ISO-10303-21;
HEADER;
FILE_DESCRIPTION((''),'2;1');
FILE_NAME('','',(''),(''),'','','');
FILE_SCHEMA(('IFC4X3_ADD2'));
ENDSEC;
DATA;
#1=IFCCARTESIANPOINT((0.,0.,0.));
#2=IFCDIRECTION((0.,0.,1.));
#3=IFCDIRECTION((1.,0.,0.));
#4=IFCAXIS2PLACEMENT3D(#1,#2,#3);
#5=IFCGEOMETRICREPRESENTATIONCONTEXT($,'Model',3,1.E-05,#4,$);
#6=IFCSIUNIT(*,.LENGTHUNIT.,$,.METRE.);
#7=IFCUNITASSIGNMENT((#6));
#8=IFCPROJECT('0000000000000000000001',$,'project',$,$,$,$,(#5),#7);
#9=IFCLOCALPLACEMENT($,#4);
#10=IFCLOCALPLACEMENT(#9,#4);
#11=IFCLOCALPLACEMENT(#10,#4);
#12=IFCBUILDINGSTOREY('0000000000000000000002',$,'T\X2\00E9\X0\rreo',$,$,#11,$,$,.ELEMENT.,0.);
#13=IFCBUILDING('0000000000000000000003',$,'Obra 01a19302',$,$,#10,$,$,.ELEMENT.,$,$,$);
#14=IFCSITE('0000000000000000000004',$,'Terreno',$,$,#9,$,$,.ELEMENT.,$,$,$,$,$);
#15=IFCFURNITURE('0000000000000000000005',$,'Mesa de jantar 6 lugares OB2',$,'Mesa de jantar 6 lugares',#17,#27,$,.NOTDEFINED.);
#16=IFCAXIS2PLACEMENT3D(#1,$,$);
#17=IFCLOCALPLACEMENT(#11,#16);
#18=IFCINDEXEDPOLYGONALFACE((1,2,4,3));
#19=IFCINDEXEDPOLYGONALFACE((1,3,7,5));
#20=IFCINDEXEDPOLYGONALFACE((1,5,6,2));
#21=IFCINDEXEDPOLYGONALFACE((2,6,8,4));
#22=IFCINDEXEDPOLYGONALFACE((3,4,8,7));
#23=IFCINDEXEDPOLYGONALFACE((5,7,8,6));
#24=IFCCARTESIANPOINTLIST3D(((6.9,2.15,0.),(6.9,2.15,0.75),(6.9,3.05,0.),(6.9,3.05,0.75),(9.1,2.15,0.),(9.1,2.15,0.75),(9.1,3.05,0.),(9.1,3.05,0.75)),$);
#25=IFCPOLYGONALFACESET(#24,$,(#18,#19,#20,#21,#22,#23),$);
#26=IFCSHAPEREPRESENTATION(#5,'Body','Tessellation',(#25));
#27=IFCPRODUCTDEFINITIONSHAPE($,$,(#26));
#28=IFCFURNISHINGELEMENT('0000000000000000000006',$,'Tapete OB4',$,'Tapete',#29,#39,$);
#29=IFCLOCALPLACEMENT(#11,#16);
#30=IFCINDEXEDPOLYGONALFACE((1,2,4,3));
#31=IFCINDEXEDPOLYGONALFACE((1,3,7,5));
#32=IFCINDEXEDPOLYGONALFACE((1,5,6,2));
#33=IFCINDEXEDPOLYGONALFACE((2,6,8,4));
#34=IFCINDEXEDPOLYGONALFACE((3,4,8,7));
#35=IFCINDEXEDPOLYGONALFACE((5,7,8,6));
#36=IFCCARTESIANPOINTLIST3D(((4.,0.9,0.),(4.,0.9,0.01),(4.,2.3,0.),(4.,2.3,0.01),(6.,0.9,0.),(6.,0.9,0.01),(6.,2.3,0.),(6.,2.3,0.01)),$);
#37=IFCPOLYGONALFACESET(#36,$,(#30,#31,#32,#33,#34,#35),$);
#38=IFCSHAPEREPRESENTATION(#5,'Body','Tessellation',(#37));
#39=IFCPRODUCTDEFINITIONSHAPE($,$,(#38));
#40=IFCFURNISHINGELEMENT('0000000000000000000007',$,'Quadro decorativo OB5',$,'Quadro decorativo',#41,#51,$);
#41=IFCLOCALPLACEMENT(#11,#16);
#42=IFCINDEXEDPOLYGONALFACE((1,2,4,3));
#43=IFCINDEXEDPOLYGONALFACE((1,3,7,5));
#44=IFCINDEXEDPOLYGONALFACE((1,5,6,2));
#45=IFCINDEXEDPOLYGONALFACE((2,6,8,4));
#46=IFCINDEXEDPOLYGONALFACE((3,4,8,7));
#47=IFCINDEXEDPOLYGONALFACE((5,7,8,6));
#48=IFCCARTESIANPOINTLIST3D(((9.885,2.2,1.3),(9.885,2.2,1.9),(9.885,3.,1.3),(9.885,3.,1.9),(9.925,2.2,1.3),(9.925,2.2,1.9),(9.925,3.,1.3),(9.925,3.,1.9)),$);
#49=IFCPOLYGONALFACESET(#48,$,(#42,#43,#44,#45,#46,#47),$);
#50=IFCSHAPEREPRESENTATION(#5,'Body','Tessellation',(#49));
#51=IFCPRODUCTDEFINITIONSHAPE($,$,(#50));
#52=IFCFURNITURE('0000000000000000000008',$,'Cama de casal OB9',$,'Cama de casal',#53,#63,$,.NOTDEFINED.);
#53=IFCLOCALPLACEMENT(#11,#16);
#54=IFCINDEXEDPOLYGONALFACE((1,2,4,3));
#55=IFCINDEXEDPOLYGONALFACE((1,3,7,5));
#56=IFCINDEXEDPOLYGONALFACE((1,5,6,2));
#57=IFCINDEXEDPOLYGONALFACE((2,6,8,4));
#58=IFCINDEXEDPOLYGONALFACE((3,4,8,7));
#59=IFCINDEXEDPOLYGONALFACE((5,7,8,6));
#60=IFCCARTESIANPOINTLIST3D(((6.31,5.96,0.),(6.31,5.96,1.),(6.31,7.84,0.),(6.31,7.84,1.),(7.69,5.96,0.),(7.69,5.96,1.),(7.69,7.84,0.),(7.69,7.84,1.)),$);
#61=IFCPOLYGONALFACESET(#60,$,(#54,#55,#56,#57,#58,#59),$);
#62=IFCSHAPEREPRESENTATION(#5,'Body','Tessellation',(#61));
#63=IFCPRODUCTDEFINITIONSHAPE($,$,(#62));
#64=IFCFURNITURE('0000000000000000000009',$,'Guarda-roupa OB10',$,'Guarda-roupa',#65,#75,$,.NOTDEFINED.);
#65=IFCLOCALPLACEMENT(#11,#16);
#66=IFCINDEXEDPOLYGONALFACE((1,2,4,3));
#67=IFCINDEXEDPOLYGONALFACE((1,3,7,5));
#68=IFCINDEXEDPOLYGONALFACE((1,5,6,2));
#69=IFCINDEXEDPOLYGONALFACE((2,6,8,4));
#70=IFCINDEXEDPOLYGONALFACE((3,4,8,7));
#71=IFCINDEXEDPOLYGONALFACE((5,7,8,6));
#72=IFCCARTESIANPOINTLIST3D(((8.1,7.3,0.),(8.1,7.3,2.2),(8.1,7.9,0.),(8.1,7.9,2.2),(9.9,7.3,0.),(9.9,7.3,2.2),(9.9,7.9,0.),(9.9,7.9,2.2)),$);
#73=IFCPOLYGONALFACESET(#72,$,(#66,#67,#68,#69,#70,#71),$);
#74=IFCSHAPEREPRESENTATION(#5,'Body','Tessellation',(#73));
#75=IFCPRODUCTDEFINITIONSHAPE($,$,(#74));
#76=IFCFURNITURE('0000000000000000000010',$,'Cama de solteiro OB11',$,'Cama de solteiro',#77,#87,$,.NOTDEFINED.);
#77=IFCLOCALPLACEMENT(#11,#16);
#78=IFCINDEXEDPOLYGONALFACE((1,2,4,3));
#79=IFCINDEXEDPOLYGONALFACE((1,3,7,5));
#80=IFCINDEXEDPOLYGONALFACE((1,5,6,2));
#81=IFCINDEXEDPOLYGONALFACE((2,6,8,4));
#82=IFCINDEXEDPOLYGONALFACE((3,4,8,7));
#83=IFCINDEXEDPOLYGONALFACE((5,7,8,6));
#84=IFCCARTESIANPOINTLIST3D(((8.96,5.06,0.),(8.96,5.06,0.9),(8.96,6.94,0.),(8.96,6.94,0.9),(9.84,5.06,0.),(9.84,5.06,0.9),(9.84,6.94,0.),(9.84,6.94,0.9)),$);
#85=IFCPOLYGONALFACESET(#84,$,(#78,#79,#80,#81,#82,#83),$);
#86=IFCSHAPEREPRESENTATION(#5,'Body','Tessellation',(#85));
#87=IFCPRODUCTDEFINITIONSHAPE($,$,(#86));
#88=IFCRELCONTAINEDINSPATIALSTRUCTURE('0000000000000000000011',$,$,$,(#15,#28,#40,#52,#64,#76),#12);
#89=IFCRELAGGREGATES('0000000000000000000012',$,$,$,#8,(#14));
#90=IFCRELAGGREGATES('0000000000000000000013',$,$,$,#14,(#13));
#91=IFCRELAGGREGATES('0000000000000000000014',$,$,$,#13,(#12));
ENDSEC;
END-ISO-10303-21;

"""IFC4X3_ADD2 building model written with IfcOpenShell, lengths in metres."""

from ifc_helpers import new_model, si_unit, frame, frame_2d, origin_with_axes, place, context, project, spatial, rectangle, extrude, element, save


model = new_model("IFC4X3_ADD2")

# Units and contexts
model_context = context("Model", 3, precision=1e-05, world=origin_with_axes())
ifc_project = project(units=[si_unit("LENGTHUNIT", "METRE")], contexts=[model_context])

# Site, building, storey
site_placement = place(None, origin_with_axes())
site = spatial("IfcSite", under=ifc_project, at=site_placement, Name="Terreno", CompositionType="ELEMENT")
building_placement = place(site_placement, origin_with_axes())
building = spatial("IfcBuilding", under=site, at=building_placement, Name="Obra 01a19302", CompositionType="ELEMENT")
storey_placement = place(building_placement, origin_with_axes())
storey = spatial("IfcBuildingStorey", under=building, at=storey_placement, Name="Térreo", CompositionType="ELEMENT", Elevation=0.0)

# Furniture
furniture_1_placement = place(storey_placement, frame((6.9, 2.15, 0.0), z_axis=(0.0, 0.0, 1.0), x_axis=(1.0, 0.0, 0.0)))
element("IfcFurniture", 1, at=furniture_1_placement, inside=storey, Name="Mesa de jantar 6 lugares OB2", ObjectType="Mesa de jantar 6 lugares", PredefinedType="NOTDEFINED", context=model_context, shape_type="SweptSolid", body=[
    extrude(rectangle(XDim=2.2, YDim=0.9, at=frame_2d((1.1, 0.45))), origin_with_axes(), (0.0, 0.0, 1.0), 0.75),
])

# Furnishing elements
furnishing_1_placement = place(storey_placement, frame((4.0, 0.9, 0.0), z_axis=(0.0, 0.0, 1.0), x_axis=(1.0, 0.0, 0.0)))
element("IfcFurnishingElement", 2, at=furnishing_1_placement, inside=storey, Name="Tapete OB4", ObjectType="Tapete", context=model_context, shape_type="SweptSolid", body=[
    extrude(rectangle(XDim=2.0, YDim=1.4, at=frame_2d((1.0, 0.7))), origin_with_axes(), (0.0, 0.0, 1.0), 0.01),
])
furnishing_2_placement = place(storey_placement, frame((9.925, 2.2, 1.3), z_axis=(0.0, 0.0, 1.0), x_axis=(0.0, 1.0, 0.0)))
element("IfcFurnishingElement", 3, at=furnishing_2_placement, inside=storey, Name="Quadro decorativo OB5", ObjectType="Quadro decorativo", context=model_context, shape_type="SweptSolid", body=[
    extrude(rectangle(XDim=0.8, YDim=0.04, at=frame_2d((0.4, 0.02))), origin_with_axes(), (0.0, 0.0, 1.0), 0.6),
])

# Furniture
furniture_2_placement = place(storey_placement, frame((6.31, 5.96, 0.0), z_axis=(0.0, 0.0, 1.0), x_axis=(1.0, 0.0, 0.0)))
element("IfcFurniture", 4, at=furniture_2_placement, inside=storey, Name="Cama de casal OB9", ObjectType="Cama de casal", PredefinedType="NOTDEFINED", context=model_context, shape_type="SweptSolid", body=[
    extrude(rectangle(XDim=1.38, YDim=1.88, at=frame_2d((0.69, 0.94))), origin_with_axes(), (0.0, 0.0, 1.0), 1.0),
])
furniture_3_placement = place(storey_placement, frame((8.1, 7.3, 0.0), z_axis=(0.0, 0.0, 1.0), x_axis=(1.0, 0.0, 0.0)))
element("IfcFurniture", 5, at=furniture_3_placement, inside=storey, Name="Guarda-roupa OB10", ObjectType="Guarda-roupa", PredefinedType="NOTDEFINED", context=model_context, shape_type="SweptSolid", body=[
    extrude(rectangle(XDim=1.8, YDim=0.6, at=frame_2d((0.9, 0.3))), origin_with_axes(), (0.0, 0.0, 1.0), 2.2),
])
furniture_4_placement = place(storey_placement, frame((8.96, 5.06, 0.0), z_axis=(0.0, 0.0, 1.0), x_axis=(1.0, 0.0, 0.0)))
element("IfcFurniture", 6, at=furniture_4_placement, inside=storey, Name="Cama de solteiro OB11", ObjectType="Cama de solteiro", PredefinedType="NOTDEFINED", context=model_context, shape_type="SweptSolid", body=[
    extrude(rectangle(XDim=0.88, YDim=1.88, at=frame_2d((0.44, 0.94))), origin_with_axes(), (0.0, 0.0, 1.0), 0.9),
])

save(model, "model.ifc")
